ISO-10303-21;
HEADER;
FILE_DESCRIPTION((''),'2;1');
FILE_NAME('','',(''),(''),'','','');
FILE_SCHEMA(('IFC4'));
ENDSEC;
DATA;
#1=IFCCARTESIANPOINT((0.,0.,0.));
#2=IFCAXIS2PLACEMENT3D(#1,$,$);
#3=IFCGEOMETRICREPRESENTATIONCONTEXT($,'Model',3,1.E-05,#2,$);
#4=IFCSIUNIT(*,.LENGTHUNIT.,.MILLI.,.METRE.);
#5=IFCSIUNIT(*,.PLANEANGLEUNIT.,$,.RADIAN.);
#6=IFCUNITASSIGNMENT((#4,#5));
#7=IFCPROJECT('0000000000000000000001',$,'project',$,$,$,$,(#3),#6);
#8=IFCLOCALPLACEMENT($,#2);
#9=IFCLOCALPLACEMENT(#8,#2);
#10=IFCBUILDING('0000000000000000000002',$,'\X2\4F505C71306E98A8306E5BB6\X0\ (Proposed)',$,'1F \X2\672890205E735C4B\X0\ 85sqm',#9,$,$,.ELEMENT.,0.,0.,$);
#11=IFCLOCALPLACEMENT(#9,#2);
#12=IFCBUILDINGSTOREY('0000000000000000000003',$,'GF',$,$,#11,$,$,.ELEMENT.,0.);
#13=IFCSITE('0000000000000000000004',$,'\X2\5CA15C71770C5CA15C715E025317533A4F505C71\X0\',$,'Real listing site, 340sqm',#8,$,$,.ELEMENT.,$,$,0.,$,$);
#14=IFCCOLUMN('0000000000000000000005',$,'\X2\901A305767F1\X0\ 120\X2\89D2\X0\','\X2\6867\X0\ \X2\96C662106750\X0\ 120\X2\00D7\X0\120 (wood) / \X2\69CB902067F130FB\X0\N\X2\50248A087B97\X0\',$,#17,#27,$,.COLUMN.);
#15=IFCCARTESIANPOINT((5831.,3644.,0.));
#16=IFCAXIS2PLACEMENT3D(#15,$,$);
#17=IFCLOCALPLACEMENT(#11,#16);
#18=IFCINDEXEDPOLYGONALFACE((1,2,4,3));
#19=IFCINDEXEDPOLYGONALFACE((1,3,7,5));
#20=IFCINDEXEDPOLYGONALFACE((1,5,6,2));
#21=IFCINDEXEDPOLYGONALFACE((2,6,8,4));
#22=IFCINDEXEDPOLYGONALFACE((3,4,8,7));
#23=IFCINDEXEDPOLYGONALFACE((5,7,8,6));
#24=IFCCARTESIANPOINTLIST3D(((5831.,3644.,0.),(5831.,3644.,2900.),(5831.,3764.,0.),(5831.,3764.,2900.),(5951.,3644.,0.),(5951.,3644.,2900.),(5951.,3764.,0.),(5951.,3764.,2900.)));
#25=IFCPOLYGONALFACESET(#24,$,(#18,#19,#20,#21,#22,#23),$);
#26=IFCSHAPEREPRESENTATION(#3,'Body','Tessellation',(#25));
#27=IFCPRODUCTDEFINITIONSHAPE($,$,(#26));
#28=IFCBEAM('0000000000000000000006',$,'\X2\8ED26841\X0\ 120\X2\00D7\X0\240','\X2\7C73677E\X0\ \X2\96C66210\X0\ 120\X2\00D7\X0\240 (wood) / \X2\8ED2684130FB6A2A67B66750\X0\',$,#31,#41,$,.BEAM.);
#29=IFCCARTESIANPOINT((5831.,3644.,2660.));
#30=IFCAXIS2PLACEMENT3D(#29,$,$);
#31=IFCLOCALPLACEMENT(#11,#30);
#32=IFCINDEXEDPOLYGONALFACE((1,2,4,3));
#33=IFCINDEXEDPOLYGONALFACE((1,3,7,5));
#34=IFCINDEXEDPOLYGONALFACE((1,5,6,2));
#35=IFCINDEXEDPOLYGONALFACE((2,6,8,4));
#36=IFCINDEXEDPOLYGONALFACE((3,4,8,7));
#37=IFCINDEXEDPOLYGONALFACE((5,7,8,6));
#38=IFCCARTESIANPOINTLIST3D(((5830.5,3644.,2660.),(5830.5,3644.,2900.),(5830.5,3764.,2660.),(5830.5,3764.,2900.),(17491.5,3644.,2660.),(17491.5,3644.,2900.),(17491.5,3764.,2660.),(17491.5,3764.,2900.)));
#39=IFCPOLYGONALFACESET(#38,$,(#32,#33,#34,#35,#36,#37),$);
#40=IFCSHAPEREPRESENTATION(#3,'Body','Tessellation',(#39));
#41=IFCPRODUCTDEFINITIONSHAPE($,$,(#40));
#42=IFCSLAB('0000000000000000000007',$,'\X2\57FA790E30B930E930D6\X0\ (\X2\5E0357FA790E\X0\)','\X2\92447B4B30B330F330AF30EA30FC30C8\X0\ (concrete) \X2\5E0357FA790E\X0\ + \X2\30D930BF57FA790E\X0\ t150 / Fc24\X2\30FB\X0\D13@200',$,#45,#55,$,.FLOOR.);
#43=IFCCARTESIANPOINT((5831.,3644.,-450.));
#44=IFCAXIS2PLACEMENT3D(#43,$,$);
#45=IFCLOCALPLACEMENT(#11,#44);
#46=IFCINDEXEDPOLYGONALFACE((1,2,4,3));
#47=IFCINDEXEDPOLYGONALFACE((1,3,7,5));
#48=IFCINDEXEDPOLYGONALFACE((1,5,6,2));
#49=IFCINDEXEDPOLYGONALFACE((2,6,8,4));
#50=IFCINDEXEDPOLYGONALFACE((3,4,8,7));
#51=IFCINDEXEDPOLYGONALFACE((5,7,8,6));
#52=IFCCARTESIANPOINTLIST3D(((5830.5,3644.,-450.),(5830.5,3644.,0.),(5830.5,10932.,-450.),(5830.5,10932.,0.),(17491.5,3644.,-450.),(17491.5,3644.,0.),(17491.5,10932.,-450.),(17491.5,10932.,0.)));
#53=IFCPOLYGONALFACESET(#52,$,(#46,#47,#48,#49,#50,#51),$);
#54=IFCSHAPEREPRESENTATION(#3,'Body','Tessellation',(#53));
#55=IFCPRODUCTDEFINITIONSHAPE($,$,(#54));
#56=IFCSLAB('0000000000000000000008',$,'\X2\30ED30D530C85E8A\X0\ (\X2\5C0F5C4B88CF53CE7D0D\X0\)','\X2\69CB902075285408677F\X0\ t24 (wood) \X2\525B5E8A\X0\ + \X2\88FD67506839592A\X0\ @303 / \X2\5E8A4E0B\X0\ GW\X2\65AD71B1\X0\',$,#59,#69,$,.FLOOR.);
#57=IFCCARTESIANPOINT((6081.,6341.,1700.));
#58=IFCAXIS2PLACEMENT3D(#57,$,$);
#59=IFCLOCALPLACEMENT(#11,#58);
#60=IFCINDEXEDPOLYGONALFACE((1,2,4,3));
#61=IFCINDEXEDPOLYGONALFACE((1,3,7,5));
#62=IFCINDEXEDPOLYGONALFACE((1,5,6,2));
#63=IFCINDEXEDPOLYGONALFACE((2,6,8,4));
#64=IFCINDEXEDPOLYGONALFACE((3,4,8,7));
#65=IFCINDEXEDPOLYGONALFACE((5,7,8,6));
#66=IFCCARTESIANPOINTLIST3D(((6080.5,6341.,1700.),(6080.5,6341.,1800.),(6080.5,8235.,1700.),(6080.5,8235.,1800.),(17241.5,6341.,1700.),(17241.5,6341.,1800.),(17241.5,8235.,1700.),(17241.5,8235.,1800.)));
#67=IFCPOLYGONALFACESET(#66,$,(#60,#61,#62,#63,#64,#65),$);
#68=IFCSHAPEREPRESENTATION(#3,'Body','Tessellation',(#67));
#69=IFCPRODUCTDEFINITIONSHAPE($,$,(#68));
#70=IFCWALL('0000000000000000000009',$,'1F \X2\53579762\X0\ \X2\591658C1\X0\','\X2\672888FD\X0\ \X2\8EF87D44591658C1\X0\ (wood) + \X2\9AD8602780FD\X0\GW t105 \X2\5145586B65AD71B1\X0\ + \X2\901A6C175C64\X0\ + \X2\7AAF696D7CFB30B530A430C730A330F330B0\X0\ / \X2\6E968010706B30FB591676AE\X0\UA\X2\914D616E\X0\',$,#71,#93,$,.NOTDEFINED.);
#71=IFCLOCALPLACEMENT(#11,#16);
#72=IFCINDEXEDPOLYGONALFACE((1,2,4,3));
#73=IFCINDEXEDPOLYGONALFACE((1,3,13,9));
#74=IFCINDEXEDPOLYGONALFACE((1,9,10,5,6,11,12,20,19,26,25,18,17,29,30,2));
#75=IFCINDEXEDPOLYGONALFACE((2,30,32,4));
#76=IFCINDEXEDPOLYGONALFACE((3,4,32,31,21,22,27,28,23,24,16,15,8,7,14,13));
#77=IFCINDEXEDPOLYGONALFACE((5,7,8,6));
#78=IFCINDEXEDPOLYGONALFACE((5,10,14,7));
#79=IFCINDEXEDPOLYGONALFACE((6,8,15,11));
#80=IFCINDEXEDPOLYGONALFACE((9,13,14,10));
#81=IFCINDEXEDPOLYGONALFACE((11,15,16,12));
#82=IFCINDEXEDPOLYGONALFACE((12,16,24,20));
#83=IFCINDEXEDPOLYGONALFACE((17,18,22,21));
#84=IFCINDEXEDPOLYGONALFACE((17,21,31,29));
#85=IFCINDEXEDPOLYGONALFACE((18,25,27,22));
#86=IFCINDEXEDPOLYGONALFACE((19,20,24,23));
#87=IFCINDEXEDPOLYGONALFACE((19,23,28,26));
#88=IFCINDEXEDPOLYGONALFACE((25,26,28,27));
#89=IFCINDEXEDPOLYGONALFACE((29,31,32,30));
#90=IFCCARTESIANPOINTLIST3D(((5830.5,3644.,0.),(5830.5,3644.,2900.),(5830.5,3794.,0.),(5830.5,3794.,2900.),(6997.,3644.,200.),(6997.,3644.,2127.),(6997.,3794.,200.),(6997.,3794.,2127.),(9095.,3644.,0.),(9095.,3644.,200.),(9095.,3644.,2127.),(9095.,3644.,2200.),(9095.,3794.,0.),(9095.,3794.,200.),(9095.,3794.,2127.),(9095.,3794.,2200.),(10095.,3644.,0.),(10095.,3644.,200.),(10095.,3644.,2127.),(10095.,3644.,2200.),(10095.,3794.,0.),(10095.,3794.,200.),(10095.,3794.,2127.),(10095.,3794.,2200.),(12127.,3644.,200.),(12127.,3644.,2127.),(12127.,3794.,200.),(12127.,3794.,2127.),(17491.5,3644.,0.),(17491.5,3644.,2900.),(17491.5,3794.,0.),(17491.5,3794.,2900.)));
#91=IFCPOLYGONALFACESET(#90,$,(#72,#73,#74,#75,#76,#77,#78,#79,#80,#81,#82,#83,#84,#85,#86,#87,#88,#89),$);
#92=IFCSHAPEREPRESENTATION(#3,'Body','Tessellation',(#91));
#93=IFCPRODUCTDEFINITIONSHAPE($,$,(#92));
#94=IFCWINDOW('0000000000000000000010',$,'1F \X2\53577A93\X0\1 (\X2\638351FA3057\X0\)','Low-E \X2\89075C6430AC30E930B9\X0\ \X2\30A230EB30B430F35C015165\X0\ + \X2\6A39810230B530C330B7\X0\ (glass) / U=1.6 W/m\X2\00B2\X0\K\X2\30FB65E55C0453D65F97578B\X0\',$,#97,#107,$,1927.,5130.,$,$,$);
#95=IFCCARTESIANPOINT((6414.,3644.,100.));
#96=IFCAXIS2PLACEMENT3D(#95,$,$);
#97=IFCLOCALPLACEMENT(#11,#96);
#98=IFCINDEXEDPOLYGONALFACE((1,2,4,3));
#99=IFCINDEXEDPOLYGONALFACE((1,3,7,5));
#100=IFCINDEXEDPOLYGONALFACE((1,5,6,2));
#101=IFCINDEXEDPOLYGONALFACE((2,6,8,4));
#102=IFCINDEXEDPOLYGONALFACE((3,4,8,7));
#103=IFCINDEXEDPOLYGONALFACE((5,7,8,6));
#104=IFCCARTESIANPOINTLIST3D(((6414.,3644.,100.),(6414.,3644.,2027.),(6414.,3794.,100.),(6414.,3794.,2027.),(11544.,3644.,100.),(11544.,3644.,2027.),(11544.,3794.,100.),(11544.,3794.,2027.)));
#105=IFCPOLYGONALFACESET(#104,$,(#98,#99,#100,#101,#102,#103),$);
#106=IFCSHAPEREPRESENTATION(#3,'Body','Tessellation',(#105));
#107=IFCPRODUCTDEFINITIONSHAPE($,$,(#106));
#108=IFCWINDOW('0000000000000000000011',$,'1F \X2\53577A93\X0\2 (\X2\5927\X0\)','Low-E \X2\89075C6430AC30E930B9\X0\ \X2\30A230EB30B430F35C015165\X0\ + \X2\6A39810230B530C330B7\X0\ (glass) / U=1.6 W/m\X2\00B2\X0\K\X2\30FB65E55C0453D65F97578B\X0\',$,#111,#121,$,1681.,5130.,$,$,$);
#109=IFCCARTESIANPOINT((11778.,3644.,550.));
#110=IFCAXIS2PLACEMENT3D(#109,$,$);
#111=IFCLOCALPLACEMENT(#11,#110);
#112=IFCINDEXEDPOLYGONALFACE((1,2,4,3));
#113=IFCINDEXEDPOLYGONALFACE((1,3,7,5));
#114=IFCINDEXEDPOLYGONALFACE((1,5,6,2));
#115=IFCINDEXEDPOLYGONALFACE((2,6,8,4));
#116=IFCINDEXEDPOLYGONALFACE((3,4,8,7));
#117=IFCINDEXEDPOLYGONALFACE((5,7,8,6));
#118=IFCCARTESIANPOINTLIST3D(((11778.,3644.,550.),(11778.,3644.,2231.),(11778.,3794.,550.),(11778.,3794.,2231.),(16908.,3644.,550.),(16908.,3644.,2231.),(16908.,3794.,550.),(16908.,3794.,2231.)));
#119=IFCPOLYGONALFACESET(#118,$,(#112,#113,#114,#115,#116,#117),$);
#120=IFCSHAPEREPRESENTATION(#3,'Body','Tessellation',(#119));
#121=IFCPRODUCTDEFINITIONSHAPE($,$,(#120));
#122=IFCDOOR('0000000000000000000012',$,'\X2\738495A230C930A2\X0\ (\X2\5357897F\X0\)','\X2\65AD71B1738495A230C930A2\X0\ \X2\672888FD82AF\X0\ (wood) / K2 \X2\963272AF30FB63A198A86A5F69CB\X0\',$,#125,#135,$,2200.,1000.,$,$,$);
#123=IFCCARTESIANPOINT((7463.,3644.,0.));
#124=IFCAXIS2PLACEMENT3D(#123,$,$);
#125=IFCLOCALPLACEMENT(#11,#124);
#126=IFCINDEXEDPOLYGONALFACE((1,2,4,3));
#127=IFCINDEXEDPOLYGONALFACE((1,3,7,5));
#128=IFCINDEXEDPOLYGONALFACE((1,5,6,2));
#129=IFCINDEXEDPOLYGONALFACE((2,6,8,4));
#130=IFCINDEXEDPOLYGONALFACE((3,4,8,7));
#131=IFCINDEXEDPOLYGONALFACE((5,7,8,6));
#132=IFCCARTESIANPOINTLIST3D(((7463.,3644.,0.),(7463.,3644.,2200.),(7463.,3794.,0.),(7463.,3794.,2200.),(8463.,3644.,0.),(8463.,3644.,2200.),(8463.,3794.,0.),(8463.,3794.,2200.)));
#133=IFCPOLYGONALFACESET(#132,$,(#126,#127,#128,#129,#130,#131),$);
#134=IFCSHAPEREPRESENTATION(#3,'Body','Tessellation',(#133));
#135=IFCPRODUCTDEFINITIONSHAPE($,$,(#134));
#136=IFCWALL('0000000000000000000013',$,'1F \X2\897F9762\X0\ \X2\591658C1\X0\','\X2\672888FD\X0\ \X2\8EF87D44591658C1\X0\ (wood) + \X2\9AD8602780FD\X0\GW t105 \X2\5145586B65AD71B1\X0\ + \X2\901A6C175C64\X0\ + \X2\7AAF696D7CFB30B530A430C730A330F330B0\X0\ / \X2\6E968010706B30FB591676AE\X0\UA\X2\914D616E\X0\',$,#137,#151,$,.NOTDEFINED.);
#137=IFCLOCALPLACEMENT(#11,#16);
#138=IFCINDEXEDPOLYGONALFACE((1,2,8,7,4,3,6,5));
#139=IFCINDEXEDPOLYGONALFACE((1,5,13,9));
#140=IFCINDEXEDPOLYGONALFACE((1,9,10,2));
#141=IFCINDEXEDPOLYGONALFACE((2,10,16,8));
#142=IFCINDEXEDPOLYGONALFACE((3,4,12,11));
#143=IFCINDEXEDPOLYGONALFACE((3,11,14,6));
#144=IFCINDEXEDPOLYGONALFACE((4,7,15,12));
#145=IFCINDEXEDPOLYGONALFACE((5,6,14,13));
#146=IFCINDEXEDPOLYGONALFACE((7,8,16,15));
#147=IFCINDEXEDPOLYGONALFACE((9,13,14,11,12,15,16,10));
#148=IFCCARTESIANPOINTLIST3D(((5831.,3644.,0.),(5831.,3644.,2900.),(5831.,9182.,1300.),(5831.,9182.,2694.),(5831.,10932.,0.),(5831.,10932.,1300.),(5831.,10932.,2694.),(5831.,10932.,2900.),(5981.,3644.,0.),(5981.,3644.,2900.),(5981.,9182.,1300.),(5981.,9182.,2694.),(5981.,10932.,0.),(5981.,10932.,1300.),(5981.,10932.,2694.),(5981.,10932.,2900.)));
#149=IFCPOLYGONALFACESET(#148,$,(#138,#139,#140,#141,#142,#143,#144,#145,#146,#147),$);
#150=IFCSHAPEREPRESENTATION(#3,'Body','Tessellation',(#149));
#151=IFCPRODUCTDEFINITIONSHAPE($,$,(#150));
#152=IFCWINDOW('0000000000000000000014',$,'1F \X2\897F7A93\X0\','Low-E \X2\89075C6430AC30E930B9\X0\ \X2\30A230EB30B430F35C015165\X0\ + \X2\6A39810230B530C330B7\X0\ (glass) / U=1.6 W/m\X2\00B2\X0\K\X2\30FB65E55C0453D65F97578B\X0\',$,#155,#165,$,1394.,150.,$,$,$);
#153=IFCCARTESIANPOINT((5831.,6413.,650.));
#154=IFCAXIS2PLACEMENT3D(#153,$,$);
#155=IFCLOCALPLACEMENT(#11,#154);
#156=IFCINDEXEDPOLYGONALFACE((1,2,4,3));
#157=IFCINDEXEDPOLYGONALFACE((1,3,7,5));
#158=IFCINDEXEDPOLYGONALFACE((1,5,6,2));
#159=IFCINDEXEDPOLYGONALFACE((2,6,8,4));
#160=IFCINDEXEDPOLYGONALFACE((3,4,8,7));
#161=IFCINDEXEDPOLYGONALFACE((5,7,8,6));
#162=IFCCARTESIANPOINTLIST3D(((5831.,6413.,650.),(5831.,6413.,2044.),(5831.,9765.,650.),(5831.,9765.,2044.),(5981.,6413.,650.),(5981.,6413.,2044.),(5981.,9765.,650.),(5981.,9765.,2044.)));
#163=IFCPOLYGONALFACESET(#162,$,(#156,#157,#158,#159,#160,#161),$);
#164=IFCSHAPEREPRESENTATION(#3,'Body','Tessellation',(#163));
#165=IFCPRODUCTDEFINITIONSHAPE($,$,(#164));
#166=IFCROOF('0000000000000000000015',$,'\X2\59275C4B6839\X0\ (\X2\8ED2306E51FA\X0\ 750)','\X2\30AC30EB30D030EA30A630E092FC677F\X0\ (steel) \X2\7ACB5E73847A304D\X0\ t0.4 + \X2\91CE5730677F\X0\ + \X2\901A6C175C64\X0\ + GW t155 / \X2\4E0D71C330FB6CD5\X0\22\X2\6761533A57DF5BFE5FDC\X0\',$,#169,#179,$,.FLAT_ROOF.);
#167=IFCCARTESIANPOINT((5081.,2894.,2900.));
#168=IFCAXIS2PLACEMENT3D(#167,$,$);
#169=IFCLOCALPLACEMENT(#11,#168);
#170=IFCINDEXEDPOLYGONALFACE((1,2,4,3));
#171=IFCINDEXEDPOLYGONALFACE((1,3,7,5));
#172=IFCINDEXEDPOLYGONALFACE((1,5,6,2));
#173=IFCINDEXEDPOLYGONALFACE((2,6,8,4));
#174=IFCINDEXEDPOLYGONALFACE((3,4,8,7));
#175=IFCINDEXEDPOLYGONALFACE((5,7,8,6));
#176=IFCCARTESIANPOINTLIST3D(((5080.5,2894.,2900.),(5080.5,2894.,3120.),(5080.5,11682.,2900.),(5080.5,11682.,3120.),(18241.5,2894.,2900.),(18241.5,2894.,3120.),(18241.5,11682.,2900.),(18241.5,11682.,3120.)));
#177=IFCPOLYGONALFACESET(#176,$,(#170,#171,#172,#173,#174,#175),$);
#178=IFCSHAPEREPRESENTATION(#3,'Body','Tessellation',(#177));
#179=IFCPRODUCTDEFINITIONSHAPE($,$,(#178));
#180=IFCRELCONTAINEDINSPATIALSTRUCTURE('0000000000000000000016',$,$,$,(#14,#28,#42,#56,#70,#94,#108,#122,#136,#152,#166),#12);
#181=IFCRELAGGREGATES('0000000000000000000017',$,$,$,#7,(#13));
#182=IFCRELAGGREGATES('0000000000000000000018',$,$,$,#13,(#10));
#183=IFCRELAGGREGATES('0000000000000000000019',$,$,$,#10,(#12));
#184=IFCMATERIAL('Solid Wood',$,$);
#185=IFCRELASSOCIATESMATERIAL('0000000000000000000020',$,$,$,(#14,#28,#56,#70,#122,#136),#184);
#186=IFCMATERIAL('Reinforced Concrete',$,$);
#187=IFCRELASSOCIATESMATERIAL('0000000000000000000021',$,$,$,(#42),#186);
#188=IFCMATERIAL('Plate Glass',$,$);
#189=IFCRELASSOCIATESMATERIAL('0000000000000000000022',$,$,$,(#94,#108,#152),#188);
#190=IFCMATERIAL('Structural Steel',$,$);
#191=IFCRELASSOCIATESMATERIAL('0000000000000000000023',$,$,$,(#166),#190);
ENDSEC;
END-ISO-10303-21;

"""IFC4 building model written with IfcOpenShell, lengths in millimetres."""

from ifc_helpers import new_model, si_unit, frame, frame_2d, origin, place, context, project, spatial, rectangle, extrude, material, element, fill, save


model = new_model("IFC4")

# Units and contexts
model_context = context("Model", 3, precision=1e-05, world=origin())
ifc_project = project(units=[si_unit("LENGTHUNIT", "METRE", prefix="MILLI"), si_unit("PLANEANGLEUNIT", "RADIAN")], contexts=[model_context])

# Site, building, storey
site_placement = place(None, origin())
site = spatial("IfcSite", under=ifc_project, at=site_placement, Name="岡山県岡山市北区佐山", ObjectType="Real listing site, 340sqm", CompositionType="ELEMENT", RefElevation=0.0)
building_placement = place(site_placement, origin())
building = spatial("IfcBuilding", under=site, at=building_placement, Name="佐山の風の家 (Proposed)", ObjectType="1F 木造平屋 85sqm", CompositionType="ELEMENT", ElevationOfRefHeight=0.0, ElevationOfTerrain=0.0)
storey_placement = place(building_placement, origin())
storey = spatial("IfcBuildingStorey", under=building, at=storey_placement, Name="GF", CompositionType="ELEMENT", Elevation=0.0)

# Column
ifc_material_1 = material(Name="Solid Wood")
column_1_placement = place(storey_placement, frame((5831.0, 3644.0, 0.0)))
element("IfcColumn", 1, at=column_1_placement, inside=storey, material=ifc_material_1, Name="通し柱 120角", Description="桧 集成材 120×120 (wood) / 構造柱・N値計算", PredefinedType="COLUMN", context=model_context, shape_type="SweptSolid", body=[
    extrude(rectangle(XDim=120.0, YDim=120.0, at=frame_2d((60.0, 60.0))), frame((5831.0, 3644.0, 0.0)), (0.0, 0.0, 1.0), 2900.0),
])

# Beam
beam_1_placement = place(storey_placement, frame((5831.0, 3644.0, 2660.0)))
element("IfcBeam", 2, at=beam_1_placement, inside=storey, material=ifc_material_1, Name="軒桁 120×240", Description="米松 集成 120×240 (wood) / 軒桁・横架材", PredefinedType="BEAM", context=model_context, shape_type="SweptSolid", body=[
    extrude(rectangle(XDim=11661.0, YDim=120.0, at=frame_2d((5830.0, 60.0))), frame((5831.0, 3644.0, 2660.0)), (0.0, 0.0, 1.0), 240.0),
])

# Slabs
ifc_material_2 = material(Name="Reinforced Concrete")
slab_1_placement = place(storey_placement, frame((5831.0, 3644.0, -450.0)))
element("IfcSlab", 3, at=slab_1_placement, inside=storey, material=ifc_material_2, Name="基礎スラブ (布基礎)", Description="鉄筋コンクリート (concrete) 布基礎 + ベタ基礎 t150 / Fc24・D13@200", PredefinedType="FLOOR", context=model_context, shape_type="SweptSolid", body=[
    extrude(rectangle(XDim=11661.0, YDim=7288.0, at=frame_2d((5830.0, 3644.0))), frame((5831.0, 3644.0, -450.0)), (0.0, 0.0, 1.0), 450.0),
])
slab_2_placement = place(storey_placement, frame((6081.0, 6341.0, 1700.0)))
element("IfcSlab", 4, at=slab_2_placement, inside=storey, material=ifc_material_1, Name="ロフト床 (小屋裏収納)", Description="構造用合板 t24 (wood) 剛床 + 製材根太 @303 / 床下 GW断熱", PredefinedType="FLOOR", context=model_context, shape_type="SweptSolid", body=[
    extrude(rectangle(XDim=11161.0, YDim=1894.0, at=frame_2d((5580.0, 947.0))), frame((6081.0, 6341.0, 1700.0)), (0.0, 0.0, 1.0), 100.0),
])

# Wall, openings, windows, door
wall_1_placement = place(storey_placement, frame((5831.0, 3644.0, 0.0)))
wall_1 = element("IfcWall", 5, at=wall_1_placement, inside=storey, material=ifc_material_1, Name="1F 南面 外壁", Description="木製 軸組外壁 (wood) + 高性能GW t105 充填断熱 + 通気層 + 窯業系サイディング / 準耐火・外皮UA配慮", PredefinedType="NOTDEFINED", context=model_context, shape_type="SweptSolid", body=[
    extrude(rectangle(XDim=11661.0, YDim=150.0, at=frame_2d((5830.0, 75.0))), frame((5831.0, 3644.0, 0.0)), (0.0, 0.0, 1.0), 2900.0),
])
opening_1_placement = place(storey_placement, frame((6414.0, 3644.0, 100.0)))
opening_1 = element("IfcOpeningElement", 6, at=opening_1_placement, cuts=wall_1, PredefinedType="NOTDEFINED", context=model_context, shape_type="SweptSolid", body=[
    extrude(rectangle(XDim=5130.0, YDim=150.0, at=frame_2d((2565.0, 75.0))), frame((6414.0, 3644.0, 100.0)), (0.0, 0.0, 1.0), 1927.0),
])
opening_2_placement = place(storey_placement, frame((11778.0, 3644.0, 550.0)))
opening_2 = element("IfcOpeningElement", 7, at=opening_2_placement, cuts=wall_1, PredefinedType="NOTDEFINED", context=model_context, shape_type="SweptSolid", body=[
    extrude(rectangle(XDim=5130.0, YDim=150.0, at=frame_2d((2565.0, 75.0))), frame((11778.0, 3644.0, 550.0)), (0.0, 0.0, 1.0), 1681.0),
])
opening_3_placement = place(storey_placement, frame((7463.0, 3644.0, 0.0)))
opening_3 = element("IfcOpeningElement", 8, at=opening_3_placement, cuts=wall_1, PredefinedType="NOTDEFINED", context=model_context, shape_type="SweptSolid", body=[
    extrude(rectangle(XDim=1000.0, YDim=150.0, at=frame_2d((500.0, 75.0))), frame((7463.0, 3644.0, 0.0)), (0.0, 0.0, 1.0), 2200.0),
])
ifc_material_3 = material(Name="Plate Glass")
window_1_placement = place(storey_placement, frame((6414.0, 3644.0, 100.0)))
window_1 = element("IfcWindow", 9, at=window_1_placement, inside=storey, material=ifc_material_3, Name="1F 南窓1 (掃出し)", Description="Low-E 複層ガラス アルゴン封入 + 樹脂サッシ (glass) / U=1.6 W/m²K・日射取得型", OverallHeight=1927.0, OverallWidth=5130.0, context=model_context, shape_type="SweptSolid", body=[
    extrude(rectangle(XDim=5130.0, YDim=150.0, at=frame_2d((2565.0, 75.0))), frame((6414.0, 3644.0, 100.0)), (0.0, 0.0, 1.0), 1927.0),
])
fill(opening_1, window_1)
window_2_placement = place(storey_placement, frame((11778.0, 3644.0, 550.0)))
window_2 = element("IfcWindow", 10, at=window_2_placement, inside=storey, material=ifc_material_3, Name="1F 南窓2 (大)", Description="Low-E 複層ガラス アルゴン封入 + 樹脂サッシ (glass) / U=1.6 W/m²K・日射取得型", OverallHeight=1681.0, OverallWidth=5130.0, context=model_context, shape_type="SweptSolid", body=[
    extrude(rectangle(XDim=5130.0, YDim=150.0, at=frame_2d((2565.0, 75.0))), frame((11778.0, 3644.0, 550.0)), (0.0, 0.0, 1.0), 1681.0),
])
fill(opening_2, window_2)
door_placement = place(storey_placement, frame((7463.0, 3644.0, 0.0)))
door = element("IfcDoor", 11, at=door_placement, inside=storey, material=ifc_material_1, Name="玄関ドア (南西)", Description="断熱玄関ドア 木製芯 (wood) / K2 防犯・採風機構", OverallHeight=2200.0, OverallWidth=1000.0, context=model_context, shape_type="SweptSolid", body=[
    extrude(rectangle(XDim=1000.0, YDim=150.0, at=frame_2d((500.0, 75.0))), frame((7463.0, 3644.0, 0.0)), (0.0, 0.0, 1.0), 2200.0),
])
fill(opening_3, door)

# Wall, opening, window
wall_2_placement = place(storey_placement, frame((5831.0, 3644.0, 0.0)))
wall_2 = element("IfcWall", 12, at=wall_2_placement, inside=storey, material=ifc_material_1, Name="1F 西面 外壁", Description="木製 軸組外壁 (wood) + 高性能GW t105 充填断熱 + 通気層 + 窯業系サイディング / 準耐火・外皮UA配慮", PredefinedType="NOTDEFINED", context=model_context, shape_type="SweptSolid", body=[
    extrude(rectangle(XDim=150.0, YDim=7288.0, at=frame_2d((75.0, 3644.0))), frame((5831.0, 3644.0, 0.0)), (0.0, 0.0, 1.0), 2900.0),
])
opening_4_placement = place(storey_placement, frame((5831.0, 6413.0, 650.0)))
opening_4 = element("IfcOpeningElement", 13, at=opening_4_placement, cuts=wall_2, PredefinedType="NOTDEFINED", context=model_context, shape_type="SweptSolid", body=[
    extrude(rectangle(XDim=150.0, YDim=3352.0, at=frame_2d((75.0, 1676.0))), frame((5831.0, 6413.0, 650.0)), (0.0, 0.0, 1.0), 1394.0),
])
window_3_placement = place(storey_placement, frame((5831.0, 6413.0, 650.0)))
window_3 = element("IfcWindow", 14, at=window_3_placement, inside=storey, material=ifc_material_3, Name="1F 西窓", Description="Low-E 複層ガラス アルゴン封入 + 樹脂サッシ (glass) / U=1.6 W/m²K・日射取得型", OverallHeight=1394.0, OverallWidth=150.0, context=model_context, shape_type="SweptSolid", body=[
    extrude(rectangle(XDim=150.0, YDim=3352.0, at=frame_2d((75.0, 1676.0))), frame((5831.0, 6413.0, 650.0)), (0.0, 0.0, 1.0), 1394.0),
])
fill(opening_4, window_3)

# Roof
ifc_material_4 = material(Name="Structural Steel")
roof_placement = place(storey_placement, frame((5081.0, 2894.0, 2900.0)))
element("IfcRoof", 15, at=roof_placement, inside=storey, material=ifc_material_4, Name="大屋根 (軒の出 750)", Description="ガルバリウム鋼板 (steel) 立平葺き t0.4 + 野地板 + 通気層 + GW t155 / 不燃・法22条区域対応", PredefinedType="FLAT_ROOF", context=model_context, shape_type="SweptSolid", body=[
    extrude(rectangle(XDim=13161.0, YDim=8788.0, at=frame_2d((6580.0, 4394.0))), frame((5081.0, 2894.0, 2900.0)), (0.0, 0.0, 1.0), 220.0),
])

save(model, "model.ifc")
